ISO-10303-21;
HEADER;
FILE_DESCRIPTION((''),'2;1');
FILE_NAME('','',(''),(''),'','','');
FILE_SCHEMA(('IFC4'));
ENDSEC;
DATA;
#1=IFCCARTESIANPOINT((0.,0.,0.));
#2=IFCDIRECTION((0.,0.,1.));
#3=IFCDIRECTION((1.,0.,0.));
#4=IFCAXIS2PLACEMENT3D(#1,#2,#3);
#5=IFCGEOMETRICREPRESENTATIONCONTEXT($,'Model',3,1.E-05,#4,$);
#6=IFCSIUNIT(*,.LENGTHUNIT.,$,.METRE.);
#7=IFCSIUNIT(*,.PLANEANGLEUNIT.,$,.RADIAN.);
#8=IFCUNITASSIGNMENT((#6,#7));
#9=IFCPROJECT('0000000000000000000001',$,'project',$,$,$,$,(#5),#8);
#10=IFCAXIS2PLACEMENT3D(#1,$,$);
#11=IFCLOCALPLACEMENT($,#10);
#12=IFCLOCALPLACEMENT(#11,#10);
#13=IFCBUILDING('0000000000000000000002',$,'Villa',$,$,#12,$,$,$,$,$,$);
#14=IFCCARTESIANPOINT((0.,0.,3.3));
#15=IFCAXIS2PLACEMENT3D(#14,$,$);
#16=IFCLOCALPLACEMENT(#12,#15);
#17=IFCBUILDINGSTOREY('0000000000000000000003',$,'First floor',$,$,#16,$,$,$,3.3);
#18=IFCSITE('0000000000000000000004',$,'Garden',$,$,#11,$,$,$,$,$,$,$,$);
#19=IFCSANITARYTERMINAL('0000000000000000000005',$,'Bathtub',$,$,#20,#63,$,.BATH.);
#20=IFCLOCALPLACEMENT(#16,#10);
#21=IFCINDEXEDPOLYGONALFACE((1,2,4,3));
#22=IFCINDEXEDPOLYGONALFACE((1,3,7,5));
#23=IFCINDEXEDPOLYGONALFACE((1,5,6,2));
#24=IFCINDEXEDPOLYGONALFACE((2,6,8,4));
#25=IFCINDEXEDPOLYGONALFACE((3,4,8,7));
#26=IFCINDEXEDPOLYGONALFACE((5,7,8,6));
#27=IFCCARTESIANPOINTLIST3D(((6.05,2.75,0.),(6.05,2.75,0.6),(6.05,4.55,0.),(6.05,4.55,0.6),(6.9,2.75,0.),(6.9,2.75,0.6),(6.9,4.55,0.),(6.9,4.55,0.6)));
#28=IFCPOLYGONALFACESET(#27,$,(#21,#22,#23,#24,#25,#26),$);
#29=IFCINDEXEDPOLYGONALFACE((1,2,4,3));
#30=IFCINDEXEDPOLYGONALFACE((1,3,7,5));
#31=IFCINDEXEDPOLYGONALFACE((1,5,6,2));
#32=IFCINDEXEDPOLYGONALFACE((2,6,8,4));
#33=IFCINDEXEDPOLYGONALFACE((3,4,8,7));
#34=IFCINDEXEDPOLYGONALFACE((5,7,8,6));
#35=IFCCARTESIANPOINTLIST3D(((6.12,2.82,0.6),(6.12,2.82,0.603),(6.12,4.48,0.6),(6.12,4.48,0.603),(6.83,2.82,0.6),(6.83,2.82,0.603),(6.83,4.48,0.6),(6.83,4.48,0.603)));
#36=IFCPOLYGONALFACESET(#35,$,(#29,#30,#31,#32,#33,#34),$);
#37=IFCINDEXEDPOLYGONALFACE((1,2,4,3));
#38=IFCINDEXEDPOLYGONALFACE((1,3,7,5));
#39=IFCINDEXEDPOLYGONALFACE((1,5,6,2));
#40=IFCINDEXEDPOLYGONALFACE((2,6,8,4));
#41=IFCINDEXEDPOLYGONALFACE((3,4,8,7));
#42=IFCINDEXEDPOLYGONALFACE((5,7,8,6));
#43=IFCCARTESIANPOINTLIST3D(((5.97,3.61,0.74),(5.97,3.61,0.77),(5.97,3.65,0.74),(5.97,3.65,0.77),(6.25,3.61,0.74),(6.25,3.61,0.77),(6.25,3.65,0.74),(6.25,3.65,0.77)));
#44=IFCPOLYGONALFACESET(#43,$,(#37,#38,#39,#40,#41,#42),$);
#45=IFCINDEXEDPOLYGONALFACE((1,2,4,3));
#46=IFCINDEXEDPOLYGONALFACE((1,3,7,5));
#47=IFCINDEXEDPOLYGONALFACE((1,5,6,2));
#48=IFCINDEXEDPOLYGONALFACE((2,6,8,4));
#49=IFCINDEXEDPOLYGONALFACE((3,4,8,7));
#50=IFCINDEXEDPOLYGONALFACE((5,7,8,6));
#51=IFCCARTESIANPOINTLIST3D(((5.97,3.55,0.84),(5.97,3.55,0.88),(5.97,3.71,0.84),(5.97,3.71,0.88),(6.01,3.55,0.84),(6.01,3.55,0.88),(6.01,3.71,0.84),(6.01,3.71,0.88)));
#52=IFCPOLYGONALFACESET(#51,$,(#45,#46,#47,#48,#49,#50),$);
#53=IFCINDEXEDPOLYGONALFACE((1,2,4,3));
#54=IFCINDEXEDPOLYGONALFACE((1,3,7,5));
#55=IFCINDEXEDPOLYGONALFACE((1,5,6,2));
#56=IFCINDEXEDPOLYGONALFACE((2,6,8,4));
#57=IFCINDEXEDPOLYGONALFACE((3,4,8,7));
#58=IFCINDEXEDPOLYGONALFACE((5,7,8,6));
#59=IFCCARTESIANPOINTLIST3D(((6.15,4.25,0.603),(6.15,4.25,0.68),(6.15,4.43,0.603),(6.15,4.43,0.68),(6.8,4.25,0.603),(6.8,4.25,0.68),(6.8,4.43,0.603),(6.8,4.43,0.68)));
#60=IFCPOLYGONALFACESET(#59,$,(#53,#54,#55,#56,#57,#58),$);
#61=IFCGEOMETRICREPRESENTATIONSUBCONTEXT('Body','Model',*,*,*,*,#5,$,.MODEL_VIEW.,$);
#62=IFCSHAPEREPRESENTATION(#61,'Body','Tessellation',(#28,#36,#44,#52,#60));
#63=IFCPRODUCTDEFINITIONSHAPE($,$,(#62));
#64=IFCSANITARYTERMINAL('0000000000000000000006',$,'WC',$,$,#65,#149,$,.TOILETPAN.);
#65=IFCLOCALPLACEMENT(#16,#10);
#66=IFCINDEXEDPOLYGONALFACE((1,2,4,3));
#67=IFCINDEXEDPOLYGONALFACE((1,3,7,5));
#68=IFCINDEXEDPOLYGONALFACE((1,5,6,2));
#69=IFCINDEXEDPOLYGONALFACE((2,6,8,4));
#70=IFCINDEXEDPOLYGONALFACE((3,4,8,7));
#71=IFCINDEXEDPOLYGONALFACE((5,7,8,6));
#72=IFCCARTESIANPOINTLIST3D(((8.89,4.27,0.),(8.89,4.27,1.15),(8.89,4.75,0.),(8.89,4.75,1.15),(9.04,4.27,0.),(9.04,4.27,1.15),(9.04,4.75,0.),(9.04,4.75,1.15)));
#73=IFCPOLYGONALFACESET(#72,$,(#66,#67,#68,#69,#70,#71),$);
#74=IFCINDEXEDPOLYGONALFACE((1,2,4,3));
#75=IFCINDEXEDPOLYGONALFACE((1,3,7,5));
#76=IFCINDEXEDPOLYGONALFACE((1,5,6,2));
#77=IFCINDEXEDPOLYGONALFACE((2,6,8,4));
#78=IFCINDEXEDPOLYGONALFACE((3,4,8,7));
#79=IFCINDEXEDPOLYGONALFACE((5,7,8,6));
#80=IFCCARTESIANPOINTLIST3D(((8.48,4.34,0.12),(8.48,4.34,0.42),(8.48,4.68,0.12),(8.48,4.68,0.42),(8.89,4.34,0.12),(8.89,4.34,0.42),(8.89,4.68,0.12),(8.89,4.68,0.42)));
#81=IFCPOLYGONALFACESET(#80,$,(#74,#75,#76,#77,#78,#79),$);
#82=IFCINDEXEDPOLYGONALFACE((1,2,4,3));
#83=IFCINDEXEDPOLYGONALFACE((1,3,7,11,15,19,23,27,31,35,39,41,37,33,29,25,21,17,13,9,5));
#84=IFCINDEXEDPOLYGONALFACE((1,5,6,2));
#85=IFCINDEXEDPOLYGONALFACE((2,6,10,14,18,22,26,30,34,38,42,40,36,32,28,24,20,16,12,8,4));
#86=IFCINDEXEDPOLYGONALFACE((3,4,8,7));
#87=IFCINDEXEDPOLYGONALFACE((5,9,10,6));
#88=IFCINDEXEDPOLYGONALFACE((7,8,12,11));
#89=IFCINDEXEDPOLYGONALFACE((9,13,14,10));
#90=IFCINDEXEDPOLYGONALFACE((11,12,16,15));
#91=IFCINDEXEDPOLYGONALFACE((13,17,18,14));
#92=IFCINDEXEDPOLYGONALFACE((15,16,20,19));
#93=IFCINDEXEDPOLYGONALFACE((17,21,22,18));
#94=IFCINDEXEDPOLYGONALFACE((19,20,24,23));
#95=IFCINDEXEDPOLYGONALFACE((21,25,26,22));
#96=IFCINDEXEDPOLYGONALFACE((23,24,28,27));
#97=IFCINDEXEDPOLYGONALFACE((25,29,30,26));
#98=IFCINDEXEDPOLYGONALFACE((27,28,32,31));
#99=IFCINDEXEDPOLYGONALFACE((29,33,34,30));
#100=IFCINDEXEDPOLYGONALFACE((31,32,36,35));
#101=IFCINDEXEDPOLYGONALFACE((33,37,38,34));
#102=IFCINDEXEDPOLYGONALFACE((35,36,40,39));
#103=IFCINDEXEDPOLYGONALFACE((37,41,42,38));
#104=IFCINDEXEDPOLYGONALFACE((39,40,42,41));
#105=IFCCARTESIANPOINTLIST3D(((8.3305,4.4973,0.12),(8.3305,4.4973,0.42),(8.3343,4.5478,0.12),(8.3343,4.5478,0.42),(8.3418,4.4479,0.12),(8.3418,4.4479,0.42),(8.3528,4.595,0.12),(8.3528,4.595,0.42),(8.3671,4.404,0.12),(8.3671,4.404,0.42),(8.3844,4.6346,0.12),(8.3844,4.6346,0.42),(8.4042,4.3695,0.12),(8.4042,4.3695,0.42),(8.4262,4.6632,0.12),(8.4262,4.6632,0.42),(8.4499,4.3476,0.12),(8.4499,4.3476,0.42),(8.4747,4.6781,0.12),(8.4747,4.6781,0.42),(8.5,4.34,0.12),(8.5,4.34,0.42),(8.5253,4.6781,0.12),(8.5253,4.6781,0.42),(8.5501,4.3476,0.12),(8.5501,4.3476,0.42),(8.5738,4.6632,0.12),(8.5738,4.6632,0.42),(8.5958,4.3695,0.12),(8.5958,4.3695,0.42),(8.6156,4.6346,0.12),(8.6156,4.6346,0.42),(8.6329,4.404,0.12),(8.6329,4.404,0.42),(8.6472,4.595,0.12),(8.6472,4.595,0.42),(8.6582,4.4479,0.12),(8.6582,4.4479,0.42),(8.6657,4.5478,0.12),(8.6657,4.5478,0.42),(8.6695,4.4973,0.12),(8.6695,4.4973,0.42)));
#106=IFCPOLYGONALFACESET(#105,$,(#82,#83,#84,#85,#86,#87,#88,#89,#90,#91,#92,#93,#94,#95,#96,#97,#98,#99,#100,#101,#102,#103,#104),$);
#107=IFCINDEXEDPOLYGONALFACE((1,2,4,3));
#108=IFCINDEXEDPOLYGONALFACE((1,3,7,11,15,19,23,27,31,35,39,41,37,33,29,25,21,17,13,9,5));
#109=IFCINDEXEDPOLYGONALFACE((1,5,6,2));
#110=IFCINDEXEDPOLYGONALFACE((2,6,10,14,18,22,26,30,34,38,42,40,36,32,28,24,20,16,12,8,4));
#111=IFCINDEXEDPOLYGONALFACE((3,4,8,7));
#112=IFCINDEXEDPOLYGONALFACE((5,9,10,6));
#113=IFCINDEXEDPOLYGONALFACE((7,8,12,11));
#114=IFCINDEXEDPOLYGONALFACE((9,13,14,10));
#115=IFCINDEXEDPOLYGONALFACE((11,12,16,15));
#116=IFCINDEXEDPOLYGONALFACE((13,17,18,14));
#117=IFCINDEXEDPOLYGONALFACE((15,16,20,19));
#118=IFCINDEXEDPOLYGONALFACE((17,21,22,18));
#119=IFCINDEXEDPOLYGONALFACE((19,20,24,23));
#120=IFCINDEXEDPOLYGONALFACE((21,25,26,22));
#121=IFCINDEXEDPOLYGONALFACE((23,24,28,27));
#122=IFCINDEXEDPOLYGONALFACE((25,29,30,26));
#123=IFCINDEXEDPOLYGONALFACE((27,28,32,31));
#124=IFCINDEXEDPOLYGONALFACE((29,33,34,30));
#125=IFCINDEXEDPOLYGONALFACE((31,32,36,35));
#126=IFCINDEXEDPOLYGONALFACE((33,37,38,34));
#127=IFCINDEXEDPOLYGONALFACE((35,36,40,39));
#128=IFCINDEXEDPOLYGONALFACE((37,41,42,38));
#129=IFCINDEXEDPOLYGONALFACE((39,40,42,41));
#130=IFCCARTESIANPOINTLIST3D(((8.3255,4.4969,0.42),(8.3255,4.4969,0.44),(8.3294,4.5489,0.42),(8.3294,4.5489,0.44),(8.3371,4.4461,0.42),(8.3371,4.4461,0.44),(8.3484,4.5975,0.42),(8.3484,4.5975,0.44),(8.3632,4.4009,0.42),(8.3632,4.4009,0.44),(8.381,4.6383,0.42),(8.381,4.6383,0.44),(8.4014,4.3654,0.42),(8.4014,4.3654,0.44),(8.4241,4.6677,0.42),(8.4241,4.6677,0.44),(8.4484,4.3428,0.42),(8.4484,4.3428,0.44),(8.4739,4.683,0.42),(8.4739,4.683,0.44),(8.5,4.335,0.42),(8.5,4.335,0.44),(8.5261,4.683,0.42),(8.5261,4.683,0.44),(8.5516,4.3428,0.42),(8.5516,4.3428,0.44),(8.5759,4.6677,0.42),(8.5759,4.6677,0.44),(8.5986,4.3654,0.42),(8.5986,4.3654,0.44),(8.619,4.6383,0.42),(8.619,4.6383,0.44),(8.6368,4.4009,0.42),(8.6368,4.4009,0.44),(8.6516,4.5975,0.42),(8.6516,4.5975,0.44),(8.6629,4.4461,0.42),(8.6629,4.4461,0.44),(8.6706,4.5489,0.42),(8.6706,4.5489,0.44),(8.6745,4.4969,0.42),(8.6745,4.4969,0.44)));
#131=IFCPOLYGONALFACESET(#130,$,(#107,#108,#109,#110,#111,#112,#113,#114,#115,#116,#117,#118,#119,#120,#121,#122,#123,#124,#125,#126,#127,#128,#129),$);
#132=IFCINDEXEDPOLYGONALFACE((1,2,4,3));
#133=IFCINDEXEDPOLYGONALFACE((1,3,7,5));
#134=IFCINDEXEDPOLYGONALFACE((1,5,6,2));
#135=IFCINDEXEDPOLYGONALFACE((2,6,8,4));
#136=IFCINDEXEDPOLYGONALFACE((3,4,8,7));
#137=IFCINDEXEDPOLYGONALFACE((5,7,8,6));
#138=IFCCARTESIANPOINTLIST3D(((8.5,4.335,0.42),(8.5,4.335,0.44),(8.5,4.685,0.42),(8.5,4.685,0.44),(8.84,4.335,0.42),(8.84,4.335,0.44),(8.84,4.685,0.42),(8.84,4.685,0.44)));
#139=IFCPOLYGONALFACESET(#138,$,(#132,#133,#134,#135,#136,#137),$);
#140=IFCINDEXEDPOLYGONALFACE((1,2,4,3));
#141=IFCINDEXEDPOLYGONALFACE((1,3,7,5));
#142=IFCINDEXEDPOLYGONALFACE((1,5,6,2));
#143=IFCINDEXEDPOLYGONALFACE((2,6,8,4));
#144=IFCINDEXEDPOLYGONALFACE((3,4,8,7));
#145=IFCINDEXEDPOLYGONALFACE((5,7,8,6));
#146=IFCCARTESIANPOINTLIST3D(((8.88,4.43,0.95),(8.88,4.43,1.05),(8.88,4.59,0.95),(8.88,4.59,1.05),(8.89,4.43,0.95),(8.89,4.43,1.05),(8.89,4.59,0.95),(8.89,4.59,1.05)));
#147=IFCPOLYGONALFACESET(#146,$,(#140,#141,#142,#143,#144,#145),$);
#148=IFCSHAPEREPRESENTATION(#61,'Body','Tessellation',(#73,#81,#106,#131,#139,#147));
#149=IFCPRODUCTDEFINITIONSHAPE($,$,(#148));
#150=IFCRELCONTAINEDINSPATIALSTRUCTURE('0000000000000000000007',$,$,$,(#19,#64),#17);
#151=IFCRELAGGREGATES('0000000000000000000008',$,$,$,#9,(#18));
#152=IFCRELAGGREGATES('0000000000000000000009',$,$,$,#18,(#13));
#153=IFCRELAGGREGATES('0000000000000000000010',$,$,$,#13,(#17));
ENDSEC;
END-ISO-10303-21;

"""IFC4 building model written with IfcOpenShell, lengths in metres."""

from ifc_helpers import new_model, si_unit, frame, frame_2d, origin, origin_with_axes, place, context, subcontext, project, spatial, rectangle, circle, extrude, element, save


model = new_model("IFC4")

# Units and contexts
model_context = context("Model", 3, precision=1e-05, world=origin_with_axes())
body_context = subcontext(model_context, "Body", "Model", "MODEL_VIEW")
ifc_project = project(units=[si_unit("LENGTHUNIT", "METRE"), si_unit("PLANEANGLEUNIT", "RADIAN")], contexts=[model_context])

# Site, building, storey
site_placement = place(None, origin())
site = spatial("IfcSite", under=ifc_project, at=site_placement, Name="Garden")
building_placement = place(site_placement, origin())
building = spatial("IfcBuilding", under=site, at=building_placement, Name="Villa")
storey_placement = place(building_placement, frame((0.0, 0.0, 3.3)))
storey = spatial("IfcBuildingStorey", under=building, at=storey_placement, Name="First floor", Elevation=3.3)

# Sanitary terminals
sanitary_terminal_1_placement = place(storey_placement, frame((6.05, 2.75, 0.0)))
element("IfcSanitaryTerminal", 1, at=sanitary_terminal_1_placement, inside=storey, Name="Bathtub", PredefinedType="BATH", context=body_context, shape_type="SweptSolid", body=[
    extrude(rectangle(XDim=0.85, YDim=1.8, at=frame_2d((0.425, 0.9))), origin(), (0.0, 0.0, 1.0), 0.6),
    extrude(rectangle(XDim=0.71, YDim=1.66, at=frame_2d((0.355, 0.83))), frame((0.07, 0.07, 0.6)), (0.0, 0.0, 1.0), 0.003),
    extrude(rectangle(XDim=0.28, YDim=0.04, at=frame_2d((0.14, 0.02))), frame((-0.08, 0.86, 0.74)), (0.0, 0.0, 1.0), 0.03),
    extrude(rectangle(XDim=0.04, YDim=0.16, at=frame_2d((0.02, 0.08))), frame((-0.08, 0.8, 0.84)), (0.0, 0.0, 1.0), 0.04),
    extrude(rectangle(XDim=0.65, YDim=0.18, at=frame_2d((0.325, 0.09))), frame((0.1, 1.5, 0.603)), (0.0, 0.0, 1.0), 0.077),
])
sanitary_terminal_2_placement = place(storey_placement, frame((8.34, 4.7, 0.0), x_axis=(0.0, -1.0, 0.0)))
element("IfcSanitaryTerminal", 2, at=sanitary_terminal_2_placement, inside=storey, Name="WC", PredefinedType="TOILETPAN", context=body_context, shape_type="SweptSolid", body=[
    extrude(rectangle(XDim=0.48, YDim=0.15, at=frame_2d((0.24, 0.075))), frame((-0.05, 0.55, 0.0)), (0.0, 0.0, 1.0), 1.15),
    extrude(rectangle(XDim=0.34, YDim=0.41, at=frame_2d((0.17, 0.205))), frame((0.02, 0.14, 0.12)), (0.0, 0.0, 1.0), 0.3),
    extrude(circle(Radius=0.17, at=frame_2d((0.19, 0.16))), frame((0.0, 0.0, 0.12)), (0.0, 0.0, 1.0), 0.3),
    extrude(circle(Radius=0.175, at=frame_2d((0.19, 0.16))), frame((0.0, 0.0, 0.42)), (0.0, 0.0, 1.0), 0.02),
    extrude(rectangle(XDim=0.35, YDim=0.34, at=frame_2d((0.175, 0.17))), frame((0.015, 0.16, 0.42)), (0.0, 0.0, 1.0), 0.02),
    extrude(rectangle(XDim=0.16, YDim=0.01, at=frame_2d((0.08, 0.005))), frame((0.11, 0.54, 0.95)), (0.0, 0.0, 1.0), 0.1),
])

save(model, "model.ifc")
